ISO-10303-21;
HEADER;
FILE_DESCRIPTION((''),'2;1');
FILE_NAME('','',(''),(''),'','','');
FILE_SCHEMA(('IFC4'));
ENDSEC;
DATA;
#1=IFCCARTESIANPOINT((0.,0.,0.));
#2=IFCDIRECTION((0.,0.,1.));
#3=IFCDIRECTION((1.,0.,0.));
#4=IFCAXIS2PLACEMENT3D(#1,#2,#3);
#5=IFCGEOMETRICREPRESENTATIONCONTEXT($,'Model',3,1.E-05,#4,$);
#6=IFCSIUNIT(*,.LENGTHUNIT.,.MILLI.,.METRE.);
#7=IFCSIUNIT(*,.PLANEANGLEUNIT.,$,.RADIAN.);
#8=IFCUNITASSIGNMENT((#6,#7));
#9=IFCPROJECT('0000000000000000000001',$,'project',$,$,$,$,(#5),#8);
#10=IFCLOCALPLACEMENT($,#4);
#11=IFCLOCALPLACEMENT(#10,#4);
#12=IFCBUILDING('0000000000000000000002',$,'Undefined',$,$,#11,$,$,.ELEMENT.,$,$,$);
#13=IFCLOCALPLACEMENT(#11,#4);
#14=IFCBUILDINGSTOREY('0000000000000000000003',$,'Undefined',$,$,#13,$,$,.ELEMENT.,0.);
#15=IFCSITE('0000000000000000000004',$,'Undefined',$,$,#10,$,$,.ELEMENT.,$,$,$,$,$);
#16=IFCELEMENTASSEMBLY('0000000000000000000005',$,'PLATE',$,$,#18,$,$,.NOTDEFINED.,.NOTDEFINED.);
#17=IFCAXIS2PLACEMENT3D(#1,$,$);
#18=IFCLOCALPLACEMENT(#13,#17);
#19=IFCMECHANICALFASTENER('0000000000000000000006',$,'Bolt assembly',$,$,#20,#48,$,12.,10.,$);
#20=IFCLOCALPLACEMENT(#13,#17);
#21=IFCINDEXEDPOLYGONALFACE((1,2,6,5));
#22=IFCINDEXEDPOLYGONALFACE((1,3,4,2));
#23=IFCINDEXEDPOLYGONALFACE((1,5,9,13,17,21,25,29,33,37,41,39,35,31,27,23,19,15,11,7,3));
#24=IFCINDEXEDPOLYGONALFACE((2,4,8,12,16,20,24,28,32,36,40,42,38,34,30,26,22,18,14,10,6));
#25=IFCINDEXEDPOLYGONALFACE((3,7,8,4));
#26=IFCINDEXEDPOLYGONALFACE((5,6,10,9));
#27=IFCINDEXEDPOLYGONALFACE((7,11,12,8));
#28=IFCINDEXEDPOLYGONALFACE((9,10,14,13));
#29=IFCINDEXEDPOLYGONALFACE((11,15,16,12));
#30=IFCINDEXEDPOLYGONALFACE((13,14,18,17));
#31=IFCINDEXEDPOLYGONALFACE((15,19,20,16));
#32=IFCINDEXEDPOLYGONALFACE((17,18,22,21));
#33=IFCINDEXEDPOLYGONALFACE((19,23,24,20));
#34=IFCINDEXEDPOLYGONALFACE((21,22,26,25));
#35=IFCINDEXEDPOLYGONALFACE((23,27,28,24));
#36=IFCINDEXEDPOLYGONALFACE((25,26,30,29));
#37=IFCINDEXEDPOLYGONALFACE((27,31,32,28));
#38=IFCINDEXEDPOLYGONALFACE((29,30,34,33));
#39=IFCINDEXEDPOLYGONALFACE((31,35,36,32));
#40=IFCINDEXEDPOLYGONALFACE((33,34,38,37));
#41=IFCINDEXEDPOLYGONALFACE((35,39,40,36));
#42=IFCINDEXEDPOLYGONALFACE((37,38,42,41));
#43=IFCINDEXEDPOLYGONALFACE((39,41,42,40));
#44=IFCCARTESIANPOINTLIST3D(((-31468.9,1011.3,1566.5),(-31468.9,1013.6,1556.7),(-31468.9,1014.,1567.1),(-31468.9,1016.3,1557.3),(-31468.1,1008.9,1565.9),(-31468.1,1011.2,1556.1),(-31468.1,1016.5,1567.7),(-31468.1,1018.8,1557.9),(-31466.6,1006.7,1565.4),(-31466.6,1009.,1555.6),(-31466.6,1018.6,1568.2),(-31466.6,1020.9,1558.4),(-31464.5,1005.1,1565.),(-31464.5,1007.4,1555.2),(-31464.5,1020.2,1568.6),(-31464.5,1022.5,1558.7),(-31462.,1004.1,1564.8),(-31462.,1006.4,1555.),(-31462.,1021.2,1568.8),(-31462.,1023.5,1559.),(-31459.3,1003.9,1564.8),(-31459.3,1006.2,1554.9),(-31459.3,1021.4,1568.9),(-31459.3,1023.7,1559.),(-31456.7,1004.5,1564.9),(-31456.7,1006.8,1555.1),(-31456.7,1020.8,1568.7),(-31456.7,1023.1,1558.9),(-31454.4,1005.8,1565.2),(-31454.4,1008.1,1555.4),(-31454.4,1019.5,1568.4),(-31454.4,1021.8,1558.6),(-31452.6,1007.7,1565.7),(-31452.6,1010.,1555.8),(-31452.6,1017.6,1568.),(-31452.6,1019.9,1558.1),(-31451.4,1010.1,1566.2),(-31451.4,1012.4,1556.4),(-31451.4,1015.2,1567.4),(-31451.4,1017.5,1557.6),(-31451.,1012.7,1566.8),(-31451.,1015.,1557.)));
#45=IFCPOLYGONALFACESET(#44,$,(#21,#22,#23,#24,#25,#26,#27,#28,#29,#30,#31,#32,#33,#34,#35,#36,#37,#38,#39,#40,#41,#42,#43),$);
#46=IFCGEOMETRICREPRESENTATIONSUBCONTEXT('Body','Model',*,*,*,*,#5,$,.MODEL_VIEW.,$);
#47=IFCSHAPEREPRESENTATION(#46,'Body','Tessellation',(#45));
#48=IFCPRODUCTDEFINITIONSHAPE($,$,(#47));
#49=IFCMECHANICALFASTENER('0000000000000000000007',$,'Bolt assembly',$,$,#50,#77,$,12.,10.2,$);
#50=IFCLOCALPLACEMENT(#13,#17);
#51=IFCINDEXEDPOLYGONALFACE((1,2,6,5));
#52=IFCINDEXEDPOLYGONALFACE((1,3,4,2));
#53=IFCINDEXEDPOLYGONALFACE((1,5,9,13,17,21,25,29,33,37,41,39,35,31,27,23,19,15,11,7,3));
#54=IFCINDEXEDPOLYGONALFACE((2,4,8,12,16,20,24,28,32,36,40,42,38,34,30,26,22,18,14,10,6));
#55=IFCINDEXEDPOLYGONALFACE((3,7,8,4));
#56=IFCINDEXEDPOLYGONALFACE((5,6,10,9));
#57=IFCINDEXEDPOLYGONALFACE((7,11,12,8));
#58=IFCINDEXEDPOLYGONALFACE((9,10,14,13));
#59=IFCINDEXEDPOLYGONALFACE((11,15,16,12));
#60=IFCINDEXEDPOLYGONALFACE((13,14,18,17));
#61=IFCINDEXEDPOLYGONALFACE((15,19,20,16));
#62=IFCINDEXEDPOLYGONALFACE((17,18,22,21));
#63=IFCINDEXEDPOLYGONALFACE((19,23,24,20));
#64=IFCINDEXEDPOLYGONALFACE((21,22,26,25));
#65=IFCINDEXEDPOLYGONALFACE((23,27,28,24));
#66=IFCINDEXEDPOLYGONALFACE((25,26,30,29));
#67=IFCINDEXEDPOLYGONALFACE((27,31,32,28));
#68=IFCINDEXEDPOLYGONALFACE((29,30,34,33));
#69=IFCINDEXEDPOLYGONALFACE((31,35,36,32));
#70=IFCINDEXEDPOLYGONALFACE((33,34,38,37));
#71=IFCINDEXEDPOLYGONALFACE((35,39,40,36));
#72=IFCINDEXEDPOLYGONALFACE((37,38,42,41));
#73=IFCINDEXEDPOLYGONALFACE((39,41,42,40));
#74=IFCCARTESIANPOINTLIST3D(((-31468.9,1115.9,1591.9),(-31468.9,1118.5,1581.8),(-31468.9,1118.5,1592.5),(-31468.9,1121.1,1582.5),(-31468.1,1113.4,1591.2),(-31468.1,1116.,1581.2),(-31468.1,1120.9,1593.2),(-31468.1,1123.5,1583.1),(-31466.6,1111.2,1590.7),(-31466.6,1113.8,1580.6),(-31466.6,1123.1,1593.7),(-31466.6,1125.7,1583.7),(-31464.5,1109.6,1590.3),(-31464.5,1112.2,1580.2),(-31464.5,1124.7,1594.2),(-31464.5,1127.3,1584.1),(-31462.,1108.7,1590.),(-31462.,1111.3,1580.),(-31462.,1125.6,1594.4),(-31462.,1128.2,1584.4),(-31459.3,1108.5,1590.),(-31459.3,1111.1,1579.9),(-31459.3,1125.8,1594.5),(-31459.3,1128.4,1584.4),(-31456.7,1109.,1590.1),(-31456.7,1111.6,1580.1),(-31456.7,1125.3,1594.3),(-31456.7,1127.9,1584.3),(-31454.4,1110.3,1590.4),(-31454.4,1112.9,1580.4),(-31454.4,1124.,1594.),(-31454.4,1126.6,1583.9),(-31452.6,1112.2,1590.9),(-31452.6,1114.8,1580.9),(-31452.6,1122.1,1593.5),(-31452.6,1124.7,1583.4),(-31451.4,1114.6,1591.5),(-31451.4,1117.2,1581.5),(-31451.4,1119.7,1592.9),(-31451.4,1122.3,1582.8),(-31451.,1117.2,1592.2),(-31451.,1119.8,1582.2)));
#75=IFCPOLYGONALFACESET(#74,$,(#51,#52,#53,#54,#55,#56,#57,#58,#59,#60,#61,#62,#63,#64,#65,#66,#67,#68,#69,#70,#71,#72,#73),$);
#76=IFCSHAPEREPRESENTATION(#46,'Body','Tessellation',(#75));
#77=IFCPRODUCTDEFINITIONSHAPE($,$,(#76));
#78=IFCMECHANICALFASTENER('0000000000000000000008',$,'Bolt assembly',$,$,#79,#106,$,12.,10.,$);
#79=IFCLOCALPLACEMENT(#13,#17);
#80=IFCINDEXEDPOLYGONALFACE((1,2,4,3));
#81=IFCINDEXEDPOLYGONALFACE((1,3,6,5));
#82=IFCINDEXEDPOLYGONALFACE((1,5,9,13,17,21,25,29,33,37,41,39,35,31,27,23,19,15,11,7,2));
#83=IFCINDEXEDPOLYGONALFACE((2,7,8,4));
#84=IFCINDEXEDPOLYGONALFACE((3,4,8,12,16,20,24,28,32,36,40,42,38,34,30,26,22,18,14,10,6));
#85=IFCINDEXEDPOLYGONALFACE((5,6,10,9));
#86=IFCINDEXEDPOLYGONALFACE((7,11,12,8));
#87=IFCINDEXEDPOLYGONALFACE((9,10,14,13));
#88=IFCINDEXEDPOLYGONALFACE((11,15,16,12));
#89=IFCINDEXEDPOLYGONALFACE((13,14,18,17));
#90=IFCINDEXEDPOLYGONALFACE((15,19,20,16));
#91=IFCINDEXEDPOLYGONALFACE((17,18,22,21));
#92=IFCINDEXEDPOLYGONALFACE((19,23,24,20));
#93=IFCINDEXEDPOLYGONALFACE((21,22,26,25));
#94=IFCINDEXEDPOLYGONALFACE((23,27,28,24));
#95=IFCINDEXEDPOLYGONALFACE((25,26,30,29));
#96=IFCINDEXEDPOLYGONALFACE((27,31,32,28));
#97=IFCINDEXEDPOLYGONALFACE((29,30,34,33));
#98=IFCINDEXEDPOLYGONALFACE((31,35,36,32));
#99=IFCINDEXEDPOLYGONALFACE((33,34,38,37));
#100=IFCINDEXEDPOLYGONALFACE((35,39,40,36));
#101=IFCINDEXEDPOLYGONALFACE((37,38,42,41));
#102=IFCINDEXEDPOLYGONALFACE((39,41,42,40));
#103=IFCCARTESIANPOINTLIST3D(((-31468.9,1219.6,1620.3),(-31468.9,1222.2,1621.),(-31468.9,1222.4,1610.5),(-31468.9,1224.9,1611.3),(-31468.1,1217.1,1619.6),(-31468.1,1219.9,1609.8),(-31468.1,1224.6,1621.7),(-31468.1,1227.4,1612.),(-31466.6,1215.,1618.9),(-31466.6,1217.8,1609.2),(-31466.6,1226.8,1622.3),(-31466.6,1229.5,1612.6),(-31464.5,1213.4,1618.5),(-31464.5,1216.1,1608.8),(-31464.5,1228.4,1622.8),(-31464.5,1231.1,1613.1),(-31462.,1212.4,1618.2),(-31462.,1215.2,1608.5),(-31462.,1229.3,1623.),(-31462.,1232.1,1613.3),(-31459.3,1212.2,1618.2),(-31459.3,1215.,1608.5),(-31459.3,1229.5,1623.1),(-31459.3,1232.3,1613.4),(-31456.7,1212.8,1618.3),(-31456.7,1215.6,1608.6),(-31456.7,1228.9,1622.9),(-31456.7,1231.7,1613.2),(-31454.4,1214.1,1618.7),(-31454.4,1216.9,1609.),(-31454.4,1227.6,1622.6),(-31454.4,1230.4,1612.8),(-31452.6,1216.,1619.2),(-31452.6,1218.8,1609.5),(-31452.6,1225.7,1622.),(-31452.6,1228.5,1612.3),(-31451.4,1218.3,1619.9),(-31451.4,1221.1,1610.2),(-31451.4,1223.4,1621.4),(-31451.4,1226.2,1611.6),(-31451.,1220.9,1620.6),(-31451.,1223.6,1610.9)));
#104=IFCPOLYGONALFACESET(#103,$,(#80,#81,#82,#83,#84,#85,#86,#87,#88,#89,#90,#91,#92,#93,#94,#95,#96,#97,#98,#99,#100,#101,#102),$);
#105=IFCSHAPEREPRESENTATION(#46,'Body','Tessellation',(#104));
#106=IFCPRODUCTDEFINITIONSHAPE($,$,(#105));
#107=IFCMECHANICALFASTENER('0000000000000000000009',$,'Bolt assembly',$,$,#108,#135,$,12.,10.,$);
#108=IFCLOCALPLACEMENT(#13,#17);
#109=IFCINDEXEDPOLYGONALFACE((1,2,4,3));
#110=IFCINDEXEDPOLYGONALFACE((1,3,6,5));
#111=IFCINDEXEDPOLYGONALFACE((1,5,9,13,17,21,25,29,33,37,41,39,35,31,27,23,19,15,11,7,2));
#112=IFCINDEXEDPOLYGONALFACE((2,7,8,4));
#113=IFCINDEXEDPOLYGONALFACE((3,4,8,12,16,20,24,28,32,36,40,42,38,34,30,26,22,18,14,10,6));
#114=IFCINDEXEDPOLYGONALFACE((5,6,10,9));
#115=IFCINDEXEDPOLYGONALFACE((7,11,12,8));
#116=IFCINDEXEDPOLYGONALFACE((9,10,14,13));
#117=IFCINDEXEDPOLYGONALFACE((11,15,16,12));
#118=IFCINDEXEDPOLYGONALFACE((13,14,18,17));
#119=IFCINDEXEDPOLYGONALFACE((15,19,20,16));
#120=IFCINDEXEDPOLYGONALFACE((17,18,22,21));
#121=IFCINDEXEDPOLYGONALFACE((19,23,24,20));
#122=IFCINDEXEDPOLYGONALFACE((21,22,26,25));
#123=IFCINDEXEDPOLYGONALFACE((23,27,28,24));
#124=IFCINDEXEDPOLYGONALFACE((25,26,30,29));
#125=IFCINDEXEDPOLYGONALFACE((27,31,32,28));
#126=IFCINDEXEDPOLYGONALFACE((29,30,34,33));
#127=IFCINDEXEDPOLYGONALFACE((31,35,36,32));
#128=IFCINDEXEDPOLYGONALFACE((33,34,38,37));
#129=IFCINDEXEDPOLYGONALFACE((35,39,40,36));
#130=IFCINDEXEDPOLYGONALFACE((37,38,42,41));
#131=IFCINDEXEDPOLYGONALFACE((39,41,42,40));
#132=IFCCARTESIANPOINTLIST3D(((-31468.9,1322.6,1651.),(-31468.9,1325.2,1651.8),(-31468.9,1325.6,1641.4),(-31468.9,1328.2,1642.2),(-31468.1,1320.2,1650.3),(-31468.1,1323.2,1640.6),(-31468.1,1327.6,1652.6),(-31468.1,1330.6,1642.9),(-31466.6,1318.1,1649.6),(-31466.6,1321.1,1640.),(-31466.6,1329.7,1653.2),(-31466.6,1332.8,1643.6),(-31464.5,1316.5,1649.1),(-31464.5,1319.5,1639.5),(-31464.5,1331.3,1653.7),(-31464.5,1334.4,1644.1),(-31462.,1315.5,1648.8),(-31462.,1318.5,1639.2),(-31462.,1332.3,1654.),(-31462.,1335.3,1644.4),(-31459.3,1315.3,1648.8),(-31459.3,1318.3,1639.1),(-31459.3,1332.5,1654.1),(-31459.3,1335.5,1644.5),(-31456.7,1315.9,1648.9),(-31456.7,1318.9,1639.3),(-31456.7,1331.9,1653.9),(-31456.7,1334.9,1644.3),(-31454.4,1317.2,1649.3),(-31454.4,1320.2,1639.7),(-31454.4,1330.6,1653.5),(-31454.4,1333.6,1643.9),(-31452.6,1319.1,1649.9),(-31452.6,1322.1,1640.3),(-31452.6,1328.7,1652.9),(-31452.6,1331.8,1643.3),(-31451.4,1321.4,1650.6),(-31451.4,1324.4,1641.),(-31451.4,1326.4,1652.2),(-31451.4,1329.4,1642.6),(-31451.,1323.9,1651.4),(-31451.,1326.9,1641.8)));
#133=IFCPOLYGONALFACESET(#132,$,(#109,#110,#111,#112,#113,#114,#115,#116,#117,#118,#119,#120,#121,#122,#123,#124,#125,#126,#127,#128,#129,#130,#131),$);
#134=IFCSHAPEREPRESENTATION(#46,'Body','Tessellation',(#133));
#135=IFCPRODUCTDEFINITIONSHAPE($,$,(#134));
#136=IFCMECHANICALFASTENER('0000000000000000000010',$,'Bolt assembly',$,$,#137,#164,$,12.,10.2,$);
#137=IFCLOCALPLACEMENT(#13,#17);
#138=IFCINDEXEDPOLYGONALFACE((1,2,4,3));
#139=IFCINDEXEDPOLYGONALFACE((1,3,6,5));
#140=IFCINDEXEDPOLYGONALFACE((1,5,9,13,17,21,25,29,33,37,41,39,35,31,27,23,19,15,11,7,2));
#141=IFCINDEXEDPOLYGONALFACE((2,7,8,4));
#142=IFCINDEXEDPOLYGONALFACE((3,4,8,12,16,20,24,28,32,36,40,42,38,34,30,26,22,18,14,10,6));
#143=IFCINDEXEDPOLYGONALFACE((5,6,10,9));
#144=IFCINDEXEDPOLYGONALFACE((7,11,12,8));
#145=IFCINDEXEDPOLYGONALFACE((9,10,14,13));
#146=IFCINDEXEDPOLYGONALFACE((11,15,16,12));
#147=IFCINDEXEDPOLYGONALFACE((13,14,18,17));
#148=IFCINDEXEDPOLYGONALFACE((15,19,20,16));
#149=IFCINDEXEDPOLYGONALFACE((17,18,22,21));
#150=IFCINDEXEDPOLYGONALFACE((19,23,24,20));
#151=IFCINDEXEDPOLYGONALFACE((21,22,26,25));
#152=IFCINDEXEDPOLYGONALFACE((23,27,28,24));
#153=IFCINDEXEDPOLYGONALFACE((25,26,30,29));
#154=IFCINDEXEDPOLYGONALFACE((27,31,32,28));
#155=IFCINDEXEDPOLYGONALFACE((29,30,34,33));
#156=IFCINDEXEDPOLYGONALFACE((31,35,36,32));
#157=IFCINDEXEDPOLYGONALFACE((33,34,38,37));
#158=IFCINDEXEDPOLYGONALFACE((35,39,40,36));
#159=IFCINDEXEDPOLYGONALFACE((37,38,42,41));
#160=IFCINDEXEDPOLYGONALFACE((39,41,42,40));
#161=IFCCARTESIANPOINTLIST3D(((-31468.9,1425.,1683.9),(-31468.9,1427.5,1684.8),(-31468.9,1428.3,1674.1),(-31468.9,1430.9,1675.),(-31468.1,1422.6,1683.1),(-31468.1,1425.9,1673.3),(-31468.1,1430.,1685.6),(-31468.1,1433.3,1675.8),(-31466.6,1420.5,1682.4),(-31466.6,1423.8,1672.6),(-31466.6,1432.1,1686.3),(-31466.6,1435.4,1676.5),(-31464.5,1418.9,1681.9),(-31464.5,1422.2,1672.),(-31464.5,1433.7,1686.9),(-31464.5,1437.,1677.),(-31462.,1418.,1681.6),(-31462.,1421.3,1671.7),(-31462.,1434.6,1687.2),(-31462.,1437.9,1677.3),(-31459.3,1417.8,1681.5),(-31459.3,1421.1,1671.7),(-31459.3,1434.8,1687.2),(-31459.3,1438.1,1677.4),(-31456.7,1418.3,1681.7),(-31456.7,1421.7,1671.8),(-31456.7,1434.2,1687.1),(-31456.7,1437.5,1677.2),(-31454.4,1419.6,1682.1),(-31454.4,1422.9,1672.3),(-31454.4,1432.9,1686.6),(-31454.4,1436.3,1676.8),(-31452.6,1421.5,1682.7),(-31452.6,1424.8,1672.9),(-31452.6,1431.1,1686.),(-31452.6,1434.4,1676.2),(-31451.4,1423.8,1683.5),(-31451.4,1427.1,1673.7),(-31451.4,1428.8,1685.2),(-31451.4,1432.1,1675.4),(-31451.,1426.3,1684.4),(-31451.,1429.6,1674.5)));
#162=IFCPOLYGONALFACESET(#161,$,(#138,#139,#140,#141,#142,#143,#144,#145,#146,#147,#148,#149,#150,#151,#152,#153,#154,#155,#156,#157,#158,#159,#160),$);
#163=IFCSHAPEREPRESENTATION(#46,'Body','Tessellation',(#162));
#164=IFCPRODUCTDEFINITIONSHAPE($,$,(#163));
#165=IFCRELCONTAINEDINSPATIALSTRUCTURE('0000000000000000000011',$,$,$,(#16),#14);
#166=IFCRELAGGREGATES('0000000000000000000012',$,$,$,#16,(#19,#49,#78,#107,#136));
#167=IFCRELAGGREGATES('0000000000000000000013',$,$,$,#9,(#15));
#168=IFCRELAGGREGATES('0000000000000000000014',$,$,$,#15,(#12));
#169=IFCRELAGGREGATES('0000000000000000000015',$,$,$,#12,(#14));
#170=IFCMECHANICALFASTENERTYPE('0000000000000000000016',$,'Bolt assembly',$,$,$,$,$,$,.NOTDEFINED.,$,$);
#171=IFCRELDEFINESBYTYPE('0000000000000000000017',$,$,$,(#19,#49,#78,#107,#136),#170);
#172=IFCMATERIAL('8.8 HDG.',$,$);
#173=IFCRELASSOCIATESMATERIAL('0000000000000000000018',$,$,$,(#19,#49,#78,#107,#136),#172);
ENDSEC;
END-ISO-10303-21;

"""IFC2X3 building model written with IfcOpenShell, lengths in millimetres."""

from ifc_helpers import new_model, si_unit, frame, origin_with_axes, origin_2d_with_axis, place, context, subcontext, project, spatial, circle, extrude, source, transform, mapped, material, type_object, element, aggregate, save


model = new_model("IFC2X3")

# Units and contexts
model_context = context("Model", 3, precision=1e-05, world=origin_with_axes())
body_context = subcontext(model_context, "Body", "Model", "MODEL_VIEW")
ifc_project = project(units=[si_unit("LENGTHUNIT", "METRE", prefix="MILLI"), si_unit("PLANEANGLEUNIT", "RADIAN")], contexts=[model_context])

# Site, building, storey
site_placement = place(None, origin_with_axes())
site = spatial("IfcSite", under=ifc_project, at=site_placement, Name="Undefined", CompositionType="ELEMENT")
building_placement = place(site_placement, origin_with_axes())
building = spatial("IfcBuilding", under=site, at=building_placement, Name="Undefined", CompositionType="ELEMENT")
storey_placement = place(building_placement, origin_with_axes())
storey = spatial("IfcBuildingStorey", under=building, at=storey_placement, Name="Undefined", CompositionType="ELEMENT", Elevation=0.0)

# Element assembly, mechanical fasteners
assembly_placement = place(storey_placement, origin_with_axes())
assembly = element("IfcElementAssembly", 1, at=assembly_placement, inside=storey, Name="PLATE", AssemblyPlace="NOTDEFINED", PredefinedType="NOTDEFINED")
ifc_material_1 = material(Name="8.8 HDG.")
mechanical_fastener_type = type_object("IfcMechanicalFastenerType", Name="Bolt assembly")
shared_shape_1 = source(origin_with_axes(), body_context, "Body", "SweptSolid", [
    extrude(circle(Radius=9.0, at=origin_2d_with_axis()), frame((0.0, 0.9, 0.0), z_axis=(0.0, 1.0, 0.0), x_axis=(1.0, 0.0, 0.0)), (0.0, 0.0, 1.0), 10.1),
])
mechanical_fastener_1_placement = place(assembly_placement, frame((-31460.0, 1015.2, 1556.1), z_axis=(0.000001, -0.973762, -0.227567), x_axis=(1.0, 0.000001, 0.0)))
mechanical_fastener_1 = element("IfcMechanicalFastener", 2, at=mechanical_fastener_1_placement, type_object=mechanical_fastener_type, material=ifc_material_1, Name="Bolt assembly", NominalDiameter=12.0, NominalLength=10.0, context=body_context, shape_type="MappedRepresentation", body=[
    mapped(shared_shape_1, transform((0.0, 0.0, 0.0))),
])
shared_shape_2 = source(origin_with_axes(), body_context, "Body", "SweptSolid", [
    extrude(circle(Radius=9.0, at=origin_2d_with_axis()), frame((0.0, 0.3, 0.0), z_axis=(0.0, 1.0, 0.0), x_axis=(1.0, 0.0, 0.0)), (0.0, 0.0, 1.0), 10.4),
])
mechanical_fastener_2_placement = place(assembly_placement, frame((-31460.0, 1119.8, 1581.9), z_axis=(0.000001, -0.967979, -0.25103), x_axis=(1.0, 0.000001, 0.0)))
mechanical_fastener_2 = element("IfcMechanicalFastener", 3, at=mechanical_fastener_2_placement, type_object=mechanical_fastener_type, material=ifc_material_1, Name="Bolt assembly", NominalDiameter=12.0, NominalLength=10.2, context=body_context, shape_type="MappedRepresentation", body=[
    mapped(shared_shape_2, transform((0.0, 0.0, 0.0))),
])
shared_shape_3 = source(origin_with_axes(), body_context, "Body", "SweptSolid", [
    extrude(circle(Radius=9.0, at=origin_2d_with_axis()), frame((0.0, 0.7, 0.0), z_axis=(0.0, 1.0, 0.0), x_axis=(1.0, 0.0, 0.0)), (0.0, 0.0, 1.0), 10.1),
])
mechanical_fastener_3_placement = place(assembly_placement, frame((-31460.0, 1223.8, 1610.2), z_axis=(0.000001, -0.961631, -0.274347), x_axis=(1.0, 0.000001, 0.0)))
mechanical_fastener_3 = element("IfcMechanicalFastener", 4, at=mechanical_fastener_3_placement, type_object=mechanical_fastener_type, material=ifc_material_1, Name="Bolt assembly", NominalDiameter=12.0, NominalLength=10.0, context=body_context, shape_type="MappedRepresentation", body=[
    mapped(shared_shape_3, transform((0.0, 0.0, 0.0))),
])
shared_shape_4 = source(origin_with_axes(), body_context, "Body", "SweptSolid", [
    extrude(circle(Radius=9.0, at=origin_2d_with_axis()), frame((0.0, 0.8, 0.0), z_axis=(0.0, 1.0, 0.0), x_axis=(1.0, 0.0, 0.0)), (0.0, 0.0, 1.0), 10.1),
])
mechanical_fastener_4_placement = place(assembly_placement, frame((-31460.0, 1327.1, 1641.0), z_axis=(0.000001, -0.954721, -0.297503), x_axis=(1.0, 0.000001, 0.0)))
mechanical_fastener_4 = element("IfcMechanicalFastener", 5, at=mechanical_fastener_4_placement, type_object=mechanical_fastener_type, material=ifc_material_1, Name="Bolt assembly", NominalDiameter=12.0, NominalLength=10.0, context=body_context, shape_type="MappedRepresentation", body=[
    mapped(shared_shape_4, transform((0.0, 0.0, 0.0))),
])
shared_shape_5 = source(origin_with_axes(), body_context, "Body", "SweptSolid", [
    extrude(circle(Radius=9.0, at=origin_2d_with_axis()), frame((0.0, 0.2, 0.0), z_axis=(0.0, 1.0, 0.0), x_axis=(1.0, 0.0, 0.0)), (0.0, 0.0, 1.0), 10.4),
])
mechanical_fastener_5_placement = place(assembly_placement, frame((-31460.0, 1429.7, 1674.4), z_axis=(0.000001, -0.947253, -0.320486), x_axis=(1.0, 0.000001, 0.0)))
mechanical_fastener_5 = element("IfcMechanicalFastener", 6, at=mechanical_fastener_5_placement, type_object=mechanical_fastener_type, material=ifc_material_1, Name="Bolt assembly", NominalDiameter=12.0, NominalLength=10.2, context=body_context, shape_type="MappedRepresentation", body=[
    mapped(shared_shape_5, transform((0.0, 0.0, 0.0))),
])
aggregate(assembly, [mechanical_fastener_1, mechanical_fastener_2, mechanical_fastener_3, mechanical_fastener_4, mechanical_fastener_5])

save(model, "model.ifc")
